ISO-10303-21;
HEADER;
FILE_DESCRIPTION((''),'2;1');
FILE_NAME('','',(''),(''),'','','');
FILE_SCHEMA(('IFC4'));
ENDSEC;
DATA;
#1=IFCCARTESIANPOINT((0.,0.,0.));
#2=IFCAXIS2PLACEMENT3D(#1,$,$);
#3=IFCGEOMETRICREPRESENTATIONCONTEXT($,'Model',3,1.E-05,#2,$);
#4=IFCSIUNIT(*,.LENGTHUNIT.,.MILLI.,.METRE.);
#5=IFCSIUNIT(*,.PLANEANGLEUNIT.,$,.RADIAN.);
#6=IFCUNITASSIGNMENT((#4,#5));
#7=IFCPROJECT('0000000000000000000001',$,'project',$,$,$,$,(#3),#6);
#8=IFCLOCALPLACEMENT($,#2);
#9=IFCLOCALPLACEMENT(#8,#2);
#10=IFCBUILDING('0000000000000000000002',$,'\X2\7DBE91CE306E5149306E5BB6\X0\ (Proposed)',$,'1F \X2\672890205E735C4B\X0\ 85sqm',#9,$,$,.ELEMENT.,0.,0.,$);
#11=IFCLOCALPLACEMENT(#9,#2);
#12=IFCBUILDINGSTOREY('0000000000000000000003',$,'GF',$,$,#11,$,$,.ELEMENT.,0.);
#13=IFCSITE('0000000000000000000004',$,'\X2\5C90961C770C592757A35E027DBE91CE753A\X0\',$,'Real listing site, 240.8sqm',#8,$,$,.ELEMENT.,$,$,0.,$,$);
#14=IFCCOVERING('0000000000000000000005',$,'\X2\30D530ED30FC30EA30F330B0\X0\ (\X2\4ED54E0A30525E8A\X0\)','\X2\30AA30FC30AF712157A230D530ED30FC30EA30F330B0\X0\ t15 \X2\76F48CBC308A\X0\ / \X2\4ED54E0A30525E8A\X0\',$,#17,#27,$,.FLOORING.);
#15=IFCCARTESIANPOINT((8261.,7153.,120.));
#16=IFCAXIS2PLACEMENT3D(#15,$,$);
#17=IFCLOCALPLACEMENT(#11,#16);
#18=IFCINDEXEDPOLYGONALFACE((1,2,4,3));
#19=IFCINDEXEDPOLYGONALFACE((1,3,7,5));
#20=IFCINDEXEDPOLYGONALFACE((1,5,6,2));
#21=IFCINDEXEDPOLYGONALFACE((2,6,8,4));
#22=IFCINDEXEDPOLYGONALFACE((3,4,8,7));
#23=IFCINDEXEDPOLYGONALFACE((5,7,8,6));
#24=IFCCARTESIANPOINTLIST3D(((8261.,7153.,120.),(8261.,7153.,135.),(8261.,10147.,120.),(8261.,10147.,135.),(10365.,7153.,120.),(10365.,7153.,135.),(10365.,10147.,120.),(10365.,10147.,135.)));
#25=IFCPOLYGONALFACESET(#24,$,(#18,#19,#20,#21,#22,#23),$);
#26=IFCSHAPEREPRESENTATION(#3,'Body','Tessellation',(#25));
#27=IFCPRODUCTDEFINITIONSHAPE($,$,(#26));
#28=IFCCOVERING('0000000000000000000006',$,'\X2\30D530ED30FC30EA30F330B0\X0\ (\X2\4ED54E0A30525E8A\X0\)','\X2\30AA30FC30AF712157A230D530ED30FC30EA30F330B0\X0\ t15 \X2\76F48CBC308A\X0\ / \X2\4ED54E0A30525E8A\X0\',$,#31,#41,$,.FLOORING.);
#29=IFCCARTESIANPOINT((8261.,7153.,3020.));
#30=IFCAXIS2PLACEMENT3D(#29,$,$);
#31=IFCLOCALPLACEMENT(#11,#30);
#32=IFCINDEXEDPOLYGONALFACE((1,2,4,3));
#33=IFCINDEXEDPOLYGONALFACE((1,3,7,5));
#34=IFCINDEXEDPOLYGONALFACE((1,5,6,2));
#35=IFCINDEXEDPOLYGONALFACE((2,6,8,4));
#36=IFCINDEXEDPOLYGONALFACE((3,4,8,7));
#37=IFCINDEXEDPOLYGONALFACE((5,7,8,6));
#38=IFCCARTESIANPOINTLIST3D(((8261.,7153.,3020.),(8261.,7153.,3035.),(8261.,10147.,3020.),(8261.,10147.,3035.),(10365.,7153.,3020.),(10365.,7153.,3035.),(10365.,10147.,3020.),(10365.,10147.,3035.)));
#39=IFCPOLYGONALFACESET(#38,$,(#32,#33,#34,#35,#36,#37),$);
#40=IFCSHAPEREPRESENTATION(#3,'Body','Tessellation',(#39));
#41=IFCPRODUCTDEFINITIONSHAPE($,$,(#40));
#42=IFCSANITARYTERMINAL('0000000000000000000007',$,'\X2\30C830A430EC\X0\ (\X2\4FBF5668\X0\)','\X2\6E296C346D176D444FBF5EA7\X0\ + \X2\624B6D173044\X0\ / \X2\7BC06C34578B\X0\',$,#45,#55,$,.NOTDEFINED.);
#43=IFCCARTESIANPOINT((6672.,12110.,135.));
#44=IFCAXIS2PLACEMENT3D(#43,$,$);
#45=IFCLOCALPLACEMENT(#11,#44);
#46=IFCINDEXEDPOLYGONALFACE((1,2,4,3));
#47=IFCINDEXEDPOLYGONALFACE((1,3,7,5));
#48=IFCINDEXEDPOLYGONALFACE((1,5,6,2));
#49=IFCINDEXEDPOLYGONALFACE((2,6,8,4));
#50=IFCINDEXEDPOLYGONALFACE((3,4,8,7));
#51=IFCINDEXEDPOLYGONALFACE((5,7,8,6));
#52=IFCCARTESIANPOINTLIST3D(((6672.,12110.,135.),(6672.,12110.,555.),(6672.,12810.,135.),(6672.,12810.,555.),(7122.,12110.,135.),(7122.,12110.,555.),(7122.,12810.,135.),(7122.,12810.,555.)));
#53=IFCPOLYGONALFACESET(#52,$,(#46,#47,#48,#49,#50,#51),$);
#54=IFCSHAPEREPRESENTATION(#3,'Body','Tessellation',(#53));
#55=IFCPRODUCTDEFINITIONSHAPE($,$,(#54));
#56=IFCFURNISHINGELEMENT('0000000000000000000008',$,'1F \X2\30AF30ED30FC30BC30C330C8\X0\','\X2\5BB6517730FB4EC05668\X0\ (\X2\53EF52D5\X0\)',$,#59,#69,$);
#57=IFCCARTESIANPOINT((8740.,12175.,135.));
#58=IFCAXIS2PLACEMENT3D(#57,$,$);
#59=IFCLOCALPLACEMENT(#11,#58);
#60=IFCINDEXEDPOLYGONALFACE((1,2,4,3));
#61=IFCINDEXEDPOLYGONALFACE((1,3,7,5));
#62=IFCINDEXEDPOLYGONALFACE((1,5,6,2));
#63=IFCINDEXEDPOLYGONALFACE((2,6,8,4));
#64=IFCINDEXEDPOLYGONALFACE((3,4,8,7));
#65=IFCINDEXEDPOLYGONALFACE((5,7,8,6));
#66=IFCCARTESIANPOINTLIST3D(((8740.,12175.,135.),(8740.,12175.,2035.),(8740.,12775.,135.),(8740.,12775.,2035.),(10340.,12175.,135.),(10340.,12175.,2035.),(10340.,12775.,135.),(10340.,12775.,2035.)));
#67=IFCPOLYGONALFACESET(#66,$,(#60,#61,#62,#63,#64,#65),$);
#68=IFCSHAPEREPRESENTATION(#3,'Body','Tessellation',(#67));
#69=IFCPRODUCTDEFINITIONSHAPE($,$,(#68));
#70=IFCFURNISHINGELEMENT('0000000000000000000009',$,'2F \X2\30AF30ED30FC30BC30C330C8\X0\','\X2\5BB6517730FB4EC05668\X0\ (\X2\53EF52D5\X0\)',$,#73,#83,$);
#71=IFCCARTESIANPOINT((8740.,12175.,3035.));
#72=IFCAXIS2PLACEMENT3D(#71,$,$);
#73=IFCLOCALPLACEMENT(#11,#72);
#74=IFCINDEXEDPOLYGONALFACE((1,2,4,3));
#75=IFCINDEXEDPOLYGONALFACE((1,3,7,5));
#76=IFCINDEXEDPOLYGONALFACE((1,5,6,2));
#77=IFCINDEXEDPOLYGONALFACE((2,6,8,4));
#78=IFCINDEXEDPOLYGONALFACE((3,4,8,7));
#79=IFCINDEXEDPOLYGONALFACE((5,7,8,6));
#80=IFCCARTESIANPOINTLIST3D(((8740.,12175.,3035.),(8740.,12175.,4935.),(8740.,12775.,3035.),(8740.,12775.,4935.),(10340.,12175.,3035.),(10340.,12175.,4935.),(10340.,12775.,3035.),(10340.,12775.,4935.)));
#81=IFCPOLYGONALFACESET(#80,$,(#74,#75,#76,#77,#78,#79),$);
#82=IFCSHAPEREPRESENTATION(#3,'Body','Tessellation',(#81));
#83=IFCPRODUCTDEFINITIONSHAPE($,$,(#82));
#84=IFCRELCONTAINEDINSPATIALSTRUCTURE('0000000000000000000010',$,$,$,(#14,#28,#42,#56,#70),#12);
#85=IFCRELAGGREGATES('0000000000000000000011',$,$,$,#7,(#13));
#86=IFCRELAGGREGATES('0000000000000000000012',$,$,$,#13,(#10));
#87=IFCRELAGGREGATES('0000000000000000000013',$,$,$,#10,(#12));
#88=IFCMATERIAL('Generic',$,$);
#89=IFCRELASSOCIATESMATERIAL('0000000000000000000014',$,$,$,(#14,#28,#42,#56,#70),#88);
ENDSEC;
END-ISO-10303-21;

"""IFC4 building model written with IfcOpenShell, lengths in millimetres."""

from ifc_helpers import new_model, si_unit, frame, frame_2d, origin, place, context, project, spatial, rectangle, extrude, material, element, save


model = new_model("IFC4")

# Units and contexts
model_context = context("Model", 3, precision=1e-05, world=origin())
ifc_project = project(units=[si_unit("LENGTHUNIT", "METRE", prefix="MILLI"), si_unit("PLANEANGLEUNIT", "RADIAN")], contexts=[model_context])

# Site, building, storey
site_placement = place(None, origin())
site = spatial("IfcSite", under=ifc_project, at=site_placement, Name="岐阜県大垣市綾野町", ObjectType="Real listing site, 240.8sqm", CompositionType="ELEMENT", RefElevation=0.0)
building_placement = place(site_placement, origin())
building = spatial("IfcBuilding", under=site, at=building_placement, Name="綾野の光の家 (Proposed)", ObjectType="1F 木造平屋 85sqm", CompositionType="ELEMENT", ElevationOfRefHeight=0.0, ElevationOfTerrain=0.0)
storey_placement = place(building_placement, origin())
storey = spatial("IfcBuildingStorey", under=building, at=storey_placement, Name="GF", CompositionType="ELEMENT", Elevation=0.0)

# Shared definitions
ifc_material_1 = material(Name="Generic")

# Coverings
covering_1_placement = place(storey_placement, frame((8261.0, 7153.0, 120.0)))
element("IfcCovering", 1, at=covering_1_placement, inside=storey, material=ifc_material_1, Name="フローリング (仕上げ床)", Description="オーク無垢フローリング t15 直貼り / 仕上げ床", PredefinedType="FLOORING", context=model_context, shape_type="SweptSolid", body=[
    extrude(rectangle(XDim=2104.0, YDim=2994.0, at=frame_2d((1052.0, 1497.0))), frame((8261.0, 7153.0, 120.0)), (0.0, 0.0, 1.0), 15.0),
])
covering_2_placement = place(storey_placement, frame((8261.0, 7153.0, 3020.0)))
element("IfcCovering", 2, at=covering_2_placement, inside=storey, material=ifc_material_1, Name="フローリング (仕上げ床)", Description="オーク無垢フローリング t15 直貼り / 仕上げ床", PredefinedType="FLOORING", context=model_context, shape_type="SweptSolid", body=[
    extrude(rectangle(XDim=2104.0, YDim=2994.0, at=frame_2d((1052.0, 1497.0))), frame((8261.0, 7153.0, 3020.0)), (0.0, 0.0, 1.0), 15.0),
])

# Sanitary terminal
sanitary_terminal_placement = place(storey_placement, frame((6672.0, 12110.0, 135.0)))
element("IfcSanitaryTerminal", 3, at=sanitary_terminal_placement, inside=storey, material=ifc_material_1, Name="トイレ (便器)", Description="温水洗浄便座 + 手洗い / 節水型", PredefinedType="NOTDEFINED", context=model_context, shape_type="SweptSolid", body=[
    extrude(rectangle(XDim=450.0, YDim=700.0, at=frame_2d((225.0, 350.0))), frame((6672.0, 12110.0, 135.0)), (0.0, 0.0, 1.0), 420.0),
])

# Furnishing elements
furnishing_1_placement = place(storey_placement, frame((8740.0, 12175.0, 135.0)))
element("IfcFurnishingElement", 4, at=furnishing_1_placement, inside=storey, material=ifc_material_1, Name="1F クローゼット", Description="家具・什器 (可動)", context=model_context, shape_type="SweptSolid", body=[
    extrude(rectangle(XDim=1600.0, YDim=600.0, at=frame_2d((800.0, 300.0))), frame((8740.0, 12175.0, 135.0)), (0.0, 0.0, 1.0), 1900.0),
])
furnishing_2_placement = place(storey_placement, frame((8740.0, 12175.0, 3035.0)))
element("IfcFurnishingElement", 5, at=furnishing_2_placement, inside=storey, material=ifc_material_1, Name="2F クローゼット", Description="家具・什器 (可動)", context=model_context, shape_type="SweptSolid", body=[
    extrude(rectangle(XDim=1600.0, YDim=600.0, at=frame_2d((800.0, 300.0))), frame((8740.0, 12175.0, 3035.0)), (0.0, 0.0, 1.0), 1900.0),
])

save(model, "model.ifc")
